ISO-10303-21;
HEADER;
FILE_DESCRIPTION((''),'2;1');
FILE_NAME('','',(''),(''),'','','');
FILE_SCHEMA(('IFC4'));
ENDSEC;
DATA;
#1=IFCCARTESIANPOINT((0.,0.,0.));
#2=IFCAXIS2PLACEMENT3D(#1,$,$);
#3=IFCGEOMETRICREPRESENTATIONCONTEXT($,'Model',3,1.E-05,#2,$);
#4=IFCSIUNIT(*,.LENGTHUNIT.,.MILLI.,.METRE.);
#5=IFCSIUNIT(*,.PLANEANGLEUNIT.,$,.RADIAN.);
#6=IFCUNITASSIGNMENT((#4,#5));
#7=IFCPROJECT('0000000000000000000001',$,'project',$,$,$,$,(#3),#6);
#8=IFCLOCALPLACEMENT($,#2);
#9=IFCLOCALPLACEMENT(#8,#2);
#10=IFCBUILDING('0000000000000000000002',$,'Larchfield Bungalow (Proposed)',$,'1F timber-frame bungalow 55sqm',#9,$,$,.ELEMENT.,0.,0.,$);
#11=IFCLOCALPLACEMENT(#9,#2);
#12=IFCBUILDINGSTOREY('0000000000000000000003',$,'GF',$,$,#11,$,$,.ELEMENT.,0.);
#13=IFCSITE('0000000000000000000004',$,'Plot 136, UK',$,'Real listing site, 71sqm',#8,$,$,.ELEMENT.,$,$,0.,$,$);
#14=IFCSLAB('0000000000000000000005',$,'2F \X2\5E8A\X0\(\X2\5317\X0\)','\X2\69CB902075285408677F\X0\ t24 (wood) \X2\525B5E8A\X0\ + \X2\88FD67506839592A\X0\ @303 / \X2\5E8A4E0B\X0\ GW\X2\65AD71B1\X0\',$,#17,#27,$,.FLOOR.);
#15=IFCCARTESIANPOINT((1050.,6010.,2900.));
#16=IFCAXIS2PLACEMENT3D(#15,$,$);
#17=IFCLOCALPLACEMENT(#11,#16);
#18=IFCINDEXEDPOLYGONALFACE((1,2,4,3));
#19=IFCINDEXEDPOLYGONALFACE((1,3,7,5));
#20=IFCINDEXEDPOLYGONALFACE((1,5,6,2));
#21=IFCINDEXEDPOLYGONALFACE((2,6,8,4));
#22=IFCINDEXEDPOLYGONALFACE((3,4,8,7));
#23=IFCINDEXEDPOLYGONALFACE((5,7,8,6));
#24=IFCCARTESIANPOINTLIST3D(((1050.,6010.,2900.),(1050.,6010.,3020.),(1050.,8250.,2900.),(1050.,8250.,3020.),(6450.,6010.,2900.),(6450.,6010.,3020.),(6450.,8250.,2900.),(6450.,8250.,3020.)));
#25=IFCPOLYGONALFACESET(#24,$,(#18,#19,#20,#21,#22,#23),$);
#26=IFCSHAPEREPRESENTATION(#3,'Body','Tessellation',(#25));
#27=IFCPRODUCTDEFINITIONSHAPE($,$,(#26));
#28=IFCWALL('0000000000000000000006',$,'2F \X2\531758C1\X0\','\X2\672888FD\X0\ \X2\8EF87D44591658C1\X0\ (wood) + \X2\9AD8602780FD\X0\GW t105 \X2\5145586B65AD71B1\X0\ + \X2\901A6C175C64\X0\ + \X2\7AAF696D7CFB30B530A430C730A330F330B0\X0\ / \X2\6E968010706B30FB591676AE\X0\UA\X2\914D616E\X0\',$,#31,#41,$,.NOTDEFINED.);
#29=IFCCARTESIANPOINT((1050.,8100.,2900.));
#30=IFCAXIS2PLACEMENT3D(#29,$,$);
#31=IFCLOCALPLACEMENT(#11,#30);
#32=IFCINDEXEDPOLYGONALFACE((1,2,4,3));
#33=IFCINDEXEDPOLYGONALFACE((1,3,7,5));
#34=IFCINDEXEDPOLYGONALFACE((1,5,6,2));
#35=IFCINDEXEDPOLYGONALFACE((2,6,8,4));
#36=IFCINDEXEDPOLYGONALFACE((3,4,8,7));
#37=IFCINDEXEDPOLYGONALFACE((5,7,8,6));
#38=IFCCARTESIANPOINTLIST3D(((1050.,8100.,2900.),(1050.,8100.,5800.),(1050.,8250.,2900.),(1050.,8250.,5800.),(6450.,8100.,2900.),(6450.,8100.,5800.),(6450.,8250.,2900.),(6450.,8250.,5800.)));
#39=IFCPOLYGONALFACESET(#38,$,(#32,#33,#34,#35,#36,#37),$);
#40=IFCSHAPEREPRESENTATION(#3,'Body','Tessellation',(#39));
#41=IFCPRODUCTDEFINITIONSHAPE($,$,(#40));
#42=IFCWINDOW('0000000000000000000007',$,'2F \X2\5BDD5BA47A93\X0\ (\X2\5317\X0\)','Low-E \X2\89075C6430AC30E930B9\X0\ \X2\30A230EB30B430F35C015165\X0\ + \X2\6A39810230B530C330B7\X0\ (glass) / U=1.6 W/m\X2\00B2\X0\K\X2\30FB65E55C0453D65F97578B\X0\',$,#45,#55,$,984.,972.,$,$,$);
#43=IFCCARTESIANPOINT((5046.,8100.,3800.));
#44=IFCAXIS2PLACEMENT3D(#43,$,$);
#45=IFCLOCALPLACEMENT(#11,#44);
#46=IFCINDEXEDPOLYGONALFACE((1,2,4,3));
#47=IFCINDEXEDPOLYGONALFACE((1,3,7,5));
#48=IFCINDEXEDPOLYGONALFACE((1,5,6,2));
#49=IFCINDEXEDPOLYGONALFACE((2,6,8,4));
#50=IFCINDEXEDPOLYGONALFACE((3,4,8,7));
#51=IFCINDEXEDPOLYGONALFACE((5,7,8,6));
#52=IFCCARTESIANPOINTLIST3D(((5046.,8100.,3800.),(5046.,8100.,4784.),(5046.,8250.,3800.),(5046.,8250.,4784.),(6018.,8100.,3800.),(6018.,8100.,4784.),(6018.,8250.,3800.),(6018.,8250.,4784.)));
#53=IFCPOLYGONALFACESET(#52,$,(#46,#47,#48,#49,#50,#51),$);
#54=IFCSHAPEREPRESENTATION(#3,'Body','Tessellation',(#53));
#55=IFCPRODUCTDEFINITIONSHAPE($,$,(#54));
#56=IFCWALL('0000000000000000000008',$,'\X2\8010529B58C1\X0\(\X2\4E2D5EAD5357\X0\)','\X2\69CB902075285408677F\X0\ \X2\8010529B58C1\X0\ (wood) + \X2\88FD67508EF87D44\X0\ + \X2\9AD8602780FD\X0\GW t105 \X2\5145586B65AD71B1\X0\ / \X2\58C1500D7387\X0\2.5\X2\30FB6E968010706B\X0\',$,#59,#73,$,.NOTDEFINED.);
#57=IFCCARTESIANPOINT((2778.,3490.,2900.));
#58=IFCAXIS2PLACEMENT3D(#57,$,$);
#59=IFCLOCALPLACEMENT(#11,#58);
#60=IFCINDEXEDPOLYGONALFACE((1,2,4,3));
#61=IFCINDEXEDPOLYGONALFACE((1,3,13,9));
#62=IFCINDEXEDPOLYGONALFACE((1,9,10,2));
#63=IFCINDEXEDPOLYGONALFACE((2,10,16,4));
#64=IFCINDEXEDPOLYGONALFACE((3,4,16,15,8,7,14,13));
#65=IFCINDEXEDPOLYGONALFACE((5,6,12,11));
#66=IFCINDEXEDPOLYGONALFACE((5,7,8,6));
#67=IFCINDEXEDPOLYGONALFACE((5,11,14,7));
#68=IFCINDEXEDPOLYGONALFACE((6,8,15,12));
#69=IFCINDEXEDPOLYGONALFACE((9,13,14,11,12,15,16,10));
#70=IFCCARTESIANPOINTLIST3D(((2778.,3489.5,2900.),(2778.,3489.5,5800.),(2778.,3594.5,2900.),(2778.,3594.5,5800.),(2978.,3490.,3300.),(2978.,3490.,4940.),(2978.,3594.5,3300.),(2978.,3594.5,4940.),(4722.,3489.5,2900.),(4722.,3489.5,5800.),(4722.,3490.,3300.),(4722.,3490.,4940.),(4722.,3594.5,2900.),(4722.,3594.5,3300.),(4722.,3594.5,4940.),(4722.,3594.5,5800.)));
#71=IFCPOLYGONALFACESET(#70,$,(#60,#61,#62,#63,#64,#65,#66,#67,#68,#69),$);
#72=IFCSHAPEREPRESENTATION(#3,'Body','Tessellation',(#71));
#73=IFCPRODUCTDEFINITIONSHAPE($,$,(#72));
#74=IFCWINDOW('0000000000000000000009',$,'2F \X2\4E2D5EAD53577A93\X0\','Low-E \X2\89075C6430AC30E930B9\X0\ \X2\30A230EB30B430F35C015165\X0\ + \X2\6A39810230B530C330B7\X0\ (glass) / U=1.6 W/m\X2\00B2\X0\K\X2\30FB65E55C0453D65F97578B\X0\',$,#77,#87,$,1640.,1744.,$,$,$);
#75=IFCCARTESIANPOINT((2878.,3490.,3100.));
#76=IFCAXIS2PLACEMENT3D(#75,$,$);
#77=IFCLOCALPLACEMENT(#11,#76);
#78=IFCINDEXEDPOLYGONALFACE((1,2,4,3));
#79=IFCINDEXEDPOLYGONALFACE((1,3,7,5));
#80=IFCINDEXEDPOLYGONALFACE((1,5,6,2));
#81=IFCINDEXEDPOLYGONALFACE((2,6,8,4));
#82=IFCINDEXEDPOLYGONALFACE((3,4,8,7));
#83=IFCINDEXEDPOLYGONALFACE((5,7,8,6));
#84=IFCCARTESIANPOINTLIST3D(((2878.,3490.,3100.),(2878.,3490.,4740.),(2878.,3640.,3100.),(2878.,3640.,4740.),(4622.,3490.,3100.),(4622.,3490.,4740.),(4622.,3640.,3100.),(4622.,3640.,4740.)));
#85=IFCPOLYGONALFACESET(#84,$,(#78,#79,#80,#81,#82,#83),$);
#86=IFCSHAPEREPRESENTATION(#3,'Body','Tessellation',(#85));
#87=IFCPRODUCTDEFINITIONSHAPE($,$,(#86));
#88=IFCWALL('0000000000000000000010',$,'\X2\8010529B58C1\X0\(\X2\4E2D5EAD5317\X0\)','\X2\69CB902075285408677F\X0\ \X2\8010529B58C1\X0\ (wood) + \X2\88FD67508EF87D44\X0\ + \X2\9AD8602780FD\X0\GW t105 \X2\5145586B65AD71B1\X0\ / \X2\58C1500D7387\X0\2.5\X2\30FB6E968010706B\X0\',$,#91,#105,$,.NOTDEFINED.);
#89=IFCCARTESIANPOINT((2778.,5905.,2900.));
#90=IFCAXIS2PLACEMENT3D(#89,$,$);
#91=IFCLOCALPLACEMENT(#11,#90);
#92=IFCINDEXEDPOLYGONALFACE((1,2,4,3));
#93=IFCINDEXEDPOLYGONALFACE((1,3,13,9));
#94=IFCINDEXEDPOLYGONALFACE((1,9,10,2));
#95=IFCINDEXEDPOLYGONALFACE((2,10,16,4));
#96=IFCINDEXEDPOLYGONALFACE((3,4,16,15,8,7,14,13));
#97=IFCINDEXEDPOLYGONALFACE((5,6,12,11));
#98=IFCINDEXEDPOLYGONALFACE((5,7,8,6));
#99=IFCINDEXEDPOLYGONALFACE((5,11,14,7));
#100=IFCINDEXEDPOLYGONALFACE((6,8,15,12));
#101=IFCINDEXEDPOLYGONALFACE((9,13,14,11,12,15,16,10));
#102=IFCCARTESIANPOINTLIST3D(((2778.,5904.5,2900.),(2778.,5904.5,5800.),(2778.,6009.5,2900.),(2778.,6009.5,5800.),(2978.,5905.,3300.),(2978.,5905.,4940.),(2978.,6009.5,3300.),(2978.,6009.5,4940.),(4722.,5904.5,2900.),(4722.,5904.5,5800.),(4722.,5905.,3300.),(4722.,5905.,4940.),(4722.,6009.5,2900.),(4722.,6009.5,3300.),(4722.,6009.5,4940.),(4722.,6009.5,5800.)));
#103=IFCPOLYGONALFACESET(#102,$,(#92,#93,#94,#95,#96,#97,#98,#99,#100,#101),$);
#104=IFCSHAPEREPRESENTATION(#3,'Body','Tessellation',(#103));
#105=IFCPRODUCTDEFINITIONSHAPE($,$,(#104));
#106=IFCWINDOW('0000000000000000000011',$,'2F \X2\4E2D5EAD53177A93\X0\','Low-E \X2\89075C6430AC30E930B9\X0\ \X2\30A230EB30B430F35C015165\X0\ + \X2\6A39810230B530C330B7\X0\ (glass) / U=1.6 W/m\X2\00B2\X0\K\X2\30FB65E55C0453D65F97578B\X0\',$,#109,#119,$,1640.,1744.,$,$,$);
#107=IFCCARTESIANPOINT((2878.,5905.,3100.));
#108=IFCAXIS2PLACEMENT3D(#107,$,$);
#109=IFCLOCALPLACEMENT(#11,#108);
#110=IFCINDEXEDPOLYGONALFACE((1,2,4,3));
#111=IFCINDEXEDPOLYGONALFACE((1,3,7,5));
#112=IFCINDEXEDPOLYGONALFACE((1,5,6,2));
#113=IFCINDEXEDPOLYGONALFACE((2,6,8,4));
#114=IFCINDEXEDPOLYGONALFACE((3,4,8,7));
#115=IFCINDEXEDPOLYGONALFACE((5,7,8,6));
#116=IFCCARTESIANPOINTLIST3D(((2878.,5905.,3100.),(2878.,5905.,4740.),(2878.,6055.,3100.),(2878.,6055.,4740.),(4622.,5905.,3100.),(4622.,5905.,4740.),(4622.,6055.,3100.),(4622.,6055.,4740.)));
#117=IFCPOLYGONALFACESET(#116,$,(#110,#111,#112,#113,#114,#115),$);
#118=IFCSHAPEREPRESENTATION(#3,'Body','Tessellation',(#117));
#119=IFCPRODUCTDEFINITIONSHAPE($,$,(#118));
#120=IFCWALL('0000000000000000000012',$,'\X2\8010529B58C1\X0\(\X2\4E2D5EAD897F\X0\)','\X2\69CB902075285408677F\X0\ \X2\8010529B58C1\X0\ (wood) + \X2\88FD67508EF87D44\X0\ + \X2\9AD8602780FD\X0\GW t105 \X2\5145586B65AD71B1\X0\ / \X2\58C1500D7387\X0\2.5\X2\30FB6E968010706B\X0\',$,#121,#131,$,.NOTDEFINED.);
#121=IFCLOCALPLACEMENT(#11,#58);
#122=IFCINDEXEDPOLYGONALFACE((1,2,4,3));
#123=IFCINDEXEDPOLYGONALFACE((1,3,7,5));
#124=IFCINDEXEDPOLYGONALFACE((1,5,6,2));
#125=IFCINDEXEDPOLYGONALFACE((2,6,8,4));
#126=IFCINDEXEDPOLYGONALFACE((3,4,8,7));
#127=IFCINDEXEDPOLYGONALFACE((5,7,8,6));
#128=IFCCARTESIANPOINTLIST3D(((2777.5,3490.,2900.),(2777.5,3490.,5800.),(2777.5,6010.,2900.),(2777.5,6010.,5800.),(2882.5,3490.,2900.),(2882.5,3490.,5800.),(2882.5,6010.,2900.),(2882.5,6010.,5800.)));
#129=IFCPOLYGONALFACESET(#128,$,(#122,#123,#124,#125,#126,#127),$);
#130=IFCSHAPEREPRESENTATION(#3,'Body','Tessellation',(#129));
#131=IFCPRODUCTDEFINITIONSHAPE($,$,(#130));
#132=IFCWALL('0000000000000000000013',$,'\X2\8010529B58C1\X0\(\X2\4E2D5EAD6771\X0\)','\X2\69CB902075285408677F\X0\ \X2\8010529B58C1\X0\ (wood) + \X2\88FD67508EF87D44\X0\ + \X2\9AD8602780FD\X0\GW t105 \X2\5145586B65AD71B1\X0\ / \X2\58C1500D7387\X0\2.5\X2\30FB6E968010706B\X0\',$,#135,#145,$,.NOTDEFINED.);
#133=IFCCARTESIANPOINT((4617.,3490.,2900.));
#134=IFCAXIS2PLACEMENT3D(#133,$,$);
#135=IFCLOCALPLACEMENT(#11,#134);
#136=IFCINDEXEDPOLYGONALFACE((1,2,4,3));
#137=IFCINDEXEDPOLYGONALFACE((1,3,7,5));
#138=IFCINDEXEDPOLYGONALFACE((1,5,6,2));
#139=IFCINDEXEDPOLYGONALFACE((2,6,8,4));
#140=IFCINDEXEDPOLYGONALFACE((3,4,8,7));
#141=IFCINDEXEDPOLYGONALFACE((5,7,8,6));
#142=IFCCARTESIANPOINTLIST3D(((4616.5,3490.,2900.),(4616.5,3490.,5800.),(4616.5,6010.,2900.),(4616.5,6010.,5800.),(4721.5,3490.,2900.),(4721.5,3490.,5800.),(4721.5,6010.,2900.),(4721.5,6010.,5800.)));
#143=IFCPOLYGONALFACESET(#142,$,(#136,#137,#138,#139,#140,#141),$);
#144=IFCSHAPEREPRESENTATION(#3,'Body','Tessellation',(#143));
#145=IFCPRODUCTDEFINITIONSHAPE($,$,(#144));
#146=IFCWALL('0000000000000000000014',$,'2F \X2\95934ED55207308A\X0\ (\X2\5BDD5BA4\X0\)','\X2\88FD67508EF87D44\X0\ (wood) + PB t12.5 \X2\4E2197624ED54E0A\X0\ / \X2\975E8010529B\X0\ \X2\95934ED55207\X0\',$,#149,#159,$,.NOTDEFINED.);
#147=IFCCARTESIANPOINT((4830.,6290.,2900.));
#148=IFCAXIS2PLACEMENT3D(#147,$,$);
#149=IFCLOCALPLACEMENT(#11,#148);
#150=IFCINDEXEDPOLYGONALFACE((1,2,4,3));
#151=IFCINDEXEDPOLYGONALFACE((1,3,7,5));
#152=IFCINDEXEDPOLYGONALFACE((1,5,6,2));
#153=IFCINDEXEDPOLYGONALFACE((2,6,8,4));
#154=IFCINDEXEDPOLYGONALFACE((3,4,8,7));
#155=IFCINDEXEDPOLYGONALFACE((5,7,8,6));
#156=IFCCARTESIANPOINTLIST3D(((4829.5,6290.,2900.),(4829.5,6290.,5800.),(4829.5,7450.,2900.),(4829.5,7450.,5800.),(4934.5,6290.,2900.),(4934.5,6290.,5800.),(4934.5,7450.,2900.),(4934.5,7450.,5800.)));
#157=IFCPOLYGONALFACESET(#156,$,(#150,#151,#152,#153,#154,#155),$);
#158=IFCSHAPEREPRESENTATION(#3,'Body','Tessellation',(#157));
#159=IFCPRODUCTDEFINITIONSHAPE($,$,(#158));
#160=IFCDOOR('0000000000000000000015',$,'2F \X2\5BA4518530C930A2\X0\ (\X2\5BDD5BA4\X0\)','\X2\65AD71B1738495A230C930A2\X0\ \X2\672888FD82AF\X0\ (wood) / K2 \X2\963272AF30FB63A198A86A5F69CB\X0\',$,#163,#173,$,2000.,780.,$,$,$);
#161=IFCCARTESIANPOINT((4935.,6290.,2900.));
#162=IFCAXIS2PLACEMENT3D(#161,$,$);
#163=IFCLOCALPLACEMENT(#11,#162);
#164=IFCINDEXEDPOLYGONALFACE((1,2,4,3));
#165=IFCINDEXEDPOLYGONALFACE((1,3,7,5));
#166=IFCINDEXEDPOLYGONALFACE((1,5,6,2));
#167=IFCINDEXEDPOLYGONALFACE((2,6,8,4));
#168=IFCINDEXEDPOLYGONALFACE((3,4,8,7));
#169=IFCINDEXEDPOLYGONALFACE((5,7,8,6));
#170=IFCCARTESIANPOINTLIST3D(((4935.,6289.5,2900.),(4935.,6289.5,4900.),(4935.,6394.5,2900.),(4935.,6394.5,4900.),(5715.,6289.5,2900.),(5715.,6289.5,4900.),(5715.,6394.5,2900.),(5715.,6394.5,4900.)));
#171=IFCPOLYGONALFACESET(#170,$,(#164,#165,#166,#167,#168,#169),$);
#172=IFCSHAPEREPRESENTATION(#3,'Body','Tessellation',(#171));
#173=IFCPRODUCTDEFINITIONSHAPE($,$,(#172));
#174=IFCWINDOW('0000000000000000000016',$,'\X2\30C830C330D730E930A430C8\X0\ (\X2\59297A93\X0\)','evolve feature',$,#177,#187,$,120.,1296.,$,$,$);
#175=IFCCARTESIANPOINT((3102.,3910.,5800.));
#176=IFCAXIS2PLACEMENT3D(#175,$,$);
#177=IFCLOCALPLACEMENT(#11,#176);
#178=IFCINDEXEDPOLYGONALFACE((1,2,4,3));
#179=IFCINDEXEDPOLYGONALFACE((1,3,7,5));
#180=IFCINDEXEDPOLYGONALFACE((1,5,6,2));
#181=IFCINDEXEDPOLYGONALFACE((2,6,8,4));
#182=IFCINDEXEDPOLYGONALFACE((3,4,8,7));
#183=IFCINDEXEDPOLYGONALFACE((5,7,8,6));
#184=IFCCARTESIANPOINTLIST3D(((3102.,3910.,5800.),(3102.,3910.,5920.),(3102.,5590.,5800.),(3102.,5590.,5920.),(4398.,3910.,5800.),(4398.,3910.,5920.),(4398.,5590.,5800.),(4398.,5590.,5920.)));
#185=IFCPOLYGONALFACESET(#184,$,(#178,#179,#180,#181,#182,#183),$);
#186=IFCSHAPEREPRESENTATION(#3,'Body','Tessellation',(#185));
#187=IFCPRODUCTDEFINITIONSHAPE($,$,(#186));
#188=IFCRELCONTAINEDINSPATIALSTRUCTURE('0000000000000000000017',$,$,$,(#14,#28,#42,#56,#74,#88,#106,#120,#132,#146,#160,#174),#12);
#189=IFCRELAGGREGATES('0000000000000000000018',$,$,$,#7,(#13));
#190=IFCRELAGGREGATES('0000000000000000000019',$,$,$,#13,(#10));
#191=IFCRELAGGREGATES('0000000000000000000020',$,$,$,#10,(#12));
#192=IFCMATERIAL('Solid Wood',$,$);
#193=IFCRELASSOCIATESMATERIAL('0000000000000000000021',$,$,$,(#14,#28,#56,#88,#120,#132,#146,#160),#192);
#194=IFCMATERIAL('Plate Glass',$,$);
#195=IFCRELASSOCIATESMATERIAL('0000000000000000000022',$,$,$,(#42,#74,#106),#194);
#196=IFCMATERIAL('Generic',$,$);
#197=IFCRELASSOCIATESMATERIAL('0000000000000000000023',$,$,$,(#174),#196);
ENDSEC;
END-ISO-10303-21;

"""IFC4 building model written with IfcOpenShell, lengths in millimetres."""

from ifc_helpers import new_model, si_unit, frame, frame_2d, origin, place, context, project, spatial, rectangle, extrude, material, element, fill, save


model = new_model("IFC4")

# Units and contexts
model_context = context("Model", 3, precision=1e-05, world=origin())
ifc_project = project(units=[si_unit("LENGTHUNIT", "METRE", prefix="MILLI"), si_unit("PLANEANGLEUNIT", "RADIAN")], contexts=[model_context])

# Site, building, storey
site_placement = place(None, origin())
site = spatial("IfcSite", under=ifc_project, at=site_placement, Name="Plot 136, UK", ObjectType="Real listing site, 71sqm", CompositionType="ELEMENT", RefElevation=0.0)
building_placement = place(site_placement, origin())
building = spatial("IfcBuilding", under=site, at=building_placement, Name="Larchfield Bungalow (Proposed)", ObjectType="1F timber-frame bungalow 55sqm", CompositionType="ELEMENT", ElevationOfRefHeight=0.0, ElevationOfTerrain=0.0)
storey_placement = place(building_placement, origin())
storey = spatial("IfcBuildingStorey", under=building, at=storey_placement, Name="GF", CompositionType="ELEMENT", Elevation=0.0)

# Slab
ifc_material_1 = material(Name="Solid Wood")
slab_placement = place(storey_placement, frame((1050.0, 6010.0, 2900.0)))
element("IfcSlab", 1, at=slab_placement, inside=storey, material=ifc_material_1, Name="2F 床(北)", Description="構造用合板 t24 (wood) 剛床 + 製材根太 @303 / 床下 GW断熱", PredefinedType="FLOOR", context=model_context, shape_type="SweptSolid", body=[
    extrude(rectangle(XDim=5400.0, YDim=2240.0, at=frame_2d((2700.0, 1120.0))), frame((1050.0, 6010.0, 2900.0)), (0.0, 0.0, 1.0), 120.0),
])

# Walls, openings, windows
wall_1_placement = place(storey_placement, frame((1050.0, 8100.0, 2900.0)))
wall_1 = element("IfcWall", 2, at=wall_1_placement, inside=storey, material=ifc_material_1, Name="2F 北壁", Description="木製 軸組外壁 (wood) + 高性能GW t105 充填断熱 + 通気層 + 窯業系サイディング / 準耐火・外皮UA配慮", PredefinedType="NOTDEFINED", context=model_context, shape_type="SweptSolid", body=[
    extrude(rectangle(XDim=5400.0, YDim=150.0, at=frame_2d((2700.0, 75.0))), frame((1050.0, 8100.0, 2900.0)), (0.0, 0.0, 1.0), 2900.0),
])
opening_1_placement = place(storey_placement, frame((5046.0, 8100.0, 3800.0)))
opening_1 = element("IfcOpeningElement", 3, at=opening_1_placement, cuts=wall_1, PredefinedType="NOTDEFINED", context=model_context, shape_type="SweptSolid", body=[
    extrude(rectangle(XDim=972.0, YDim=150.0, at=frame_2d((486.0, 75.0))), frame((5046.0, 8100.0, 3800.0)), (0.0, 0.0, 1.0), 984.0),
])
ifc_material_2 = material(Name="Plate Glass")
window_1_placement = place(storey_placement, frame((5046.0, 8100.0, 3800.0)))
window_1 = element("IfcWindow", 4, at=window_1_placement, inside=storey, material=ifc_material_2, Name="2F 寝室窓 (北)", Description="Low-E 複層ガラス アルゴン封入 + 樹脂サッシ (glass) / U=1.6 W/m²K・日射取得型", OverallHeight=984.0, OverallWidth=972.0, context=model_context, shape_type="SweptSolid", body=[
    extrude(rectangle(XDim=972.0, YDim=150.0, at=frame_2d((486.0, 75.0))), frame((5046.0, 8100.0, 3800.0)), (0.0, 0.0, 1.0), 984.0),
])
fill(opening_1, window_1)
wall_2_placement = place(storey_placement, frame((2778.0, 3490.0, 2900.0)))
wall_2 = element("IfcWall", 5, at=wall_2_placement, inside=storey, material=ifc_material_1, Name="耐力壁(中庭南)", Description="構造用合板 耐力壁 (wood) + 製材軸組 + 高性能GW t105 充填断熱 / 壁倍率2.5・準耐火", PredefinedType="NOTDEFINED", context=model_context, shape_type="SweptSolid", body=[
    extrude(rectangle(XDim=1944.0, YDim=105.0, at=frame_2d((972.0, 52.0))), frame((2778.0, 3490.0, 2900.0)), (0.0, 0.0, 1.0), 2900.0),
])
opening_2_placement = place(storey_placement, frame((2878.0, 3490.0, 3100.0)))
opening_2 = element("IfcOpeningElement", 6, at=opening_2_placement, cuts=wall_2, PredefinedType="NOTDEFINED", context=model_context, shape_type="SweptSolid", body=[
    extrude(rectangle(XDim=1744.0, YDim=150.0, at=frame_2d((872.0, 75.0))), frame((2878.0, 3490.0, 3100.0)), (0.0, 0.0, 1.0), 1640.0),
])
window_2_placement = place(storey_placement, frame((2878.0, 3490.0, 3100.0)))
window_2 = element("IfcWindow", 7, at=window_2_placement, inside=storey, material=ifc_material_2, Name="2F 中庭南窓", Description="Low-E 複層ガラス アルゴン封入 + 樹脂サッシ (glass) / U=1.6 W/m²K・日射取得型", OverallHeight=1640.0, OverallWidth=1744.0, context=model_context, shape_type="SweptSolid", body=[
    extrude(rectangle(XDim=1744.0, YDim=150.0, at=frame_2d((872.0, 75.0))), frame((2878.0, 3490.0, 3100.0)), (0.0, 0.0, 1.0), 1640.0),
])
fill(opening_2, window_2)
wall_3_placement = place(storey_placement, frame((2778.0, 5905.0, 2900.0)))
wall_3 = element("IfcWall", 8, at=wall_3_placement, inside=storey, material=ifc_material_1, Name="耐力壁(中庭北)", Description="構造用合板 耐力壁 (wood) + 製材軸組 + 高性能GW t105 充填断熱 / 壁倍率2.5・準耐火", PredefinedType="NOTDEFINED", context=model_context, shape_type="SweptSolid", body=[
    extrude(rectangle(XDim=1944.0, YDim=105.0, at=frame_2d((972.0, 52.0))), frame((2778.0, 5905.0, 2900.0)), (0.0, 0.0, 1.0), 2900.0),
])
opening_3_placement = place(storey_placement, frame((2878.0, 5905.0, 3100.0)))
opening_3 = element("IfcOpeningElement", 9, at=opening_3_placement, cuts=wall_3, PredefinedType="NOTDEFINED", context=model_context, shape_type="SweptSolid", body=[
    extrude(rectangle(XDim=1744.0, YDim=150.0, at=frame_2d((872.0, 75.0))), frame((2878.0, 5905.0, 3100.0)), (0.0, 0.0, 1.0), 1640.0),
])
window_3_placement = place(storey_placement, frame((2878.0, 5905.0, 3100.0)))
window_3 = element("IfcWindow", 10, at=window_3_placement, inside=storey, material=ifc_material_2, Name="2F 中庭北窓", Description="Low-E 複層ガラス アルゴン封入 + 樹脂サッシ (glass) / U=1.6 W/m²K・日射取得型", OverallHeight=1640.0, OverallWidth=1744.0, context=model_context, shape_type="SweptSolid", body=[
    extrude(rectangle(XDim=1744.0, YDim=150.0, at=frame_2d((872.0, 75.0))), frame((2878.0, 5905.0, 3100.0)), (0.0, 0.0, 1.0), 1640.0),
])
fill(opening_3, window_3)

# Walls
wall_4_placement = place(storey_placement, frame((2778.0, 3490.0, 2900.0)))
element("IfcWall", 11, at=wall_4_placement, inside=storey, material=ifc_material_1, Name="耐力壁(中庭西)", Description="構造用合板 耐力壁 (wood) + 製材軸組 + 高性能GW t105 充填断熱 / 壁倍率2.5・準耐火", PredefinedType="NOTDEFINED", context=model_context, shape_type="SweptSolid", body=[
    extrude(rectangle(XDim=105.0, YDim=2520.0, at=frame_2d((52.0, 1260.0))), frame((2778.0, 3490.0, 2900.0)), (0.0, 0.0, 1.0), 2900.0),
])
wall_5_placement = place(storey_placement, frame((4617.0, 3490.0, 2900.0)))
element("IfcWall", 12, at=wall_5_placement, inside=storey, material=ifc_material_1, Name="耐力壁(中庭東)", Description="構造用合板 耐力壁 (wood) + 製材軸組 + 高性能GW t105 充填断熱 / 壁倍率2.5・準耐火", PredefinedType="NOTDEFINED", context=model_context, shape_type="SweptSolid", body=[
    extrude(rectangle(XDim=105.0, YDim=2520.0, at=frame_2d((52.0, 1260.0))), frame((4617.0, 3490.0, 2900.0)), (0.0, 0.0, 1.0), 2900.0),
])
wall_6_placement = place(storey_placement, frame((4830.0, 6290.0, 2900.0)))
element("IfcWall", 13, at=wall_6_placement, inside=storey, material=ifc_material_1, Name="2F 間仕切り (寝室)", Description="製材軸組 (wood) + PB t12.5 両面仕上 / 非耐力 間仕切", PredefinedType="NOTDEFINED", context=model_context, shape_type="SweptSolid", body=[
    extrude(rectangle(XDim=105.0, YDim=1160.0, at=frame_2d((52.0, 580.0))), frame((4830.0, 6290.0, 2900.0)), (0.0, 0.0, 1.0), 2900.0),
])

# Door
door_placement = place(storey_placement, frame((4935.0, 6290.0, 2900.0)))
element("IfcDoor", 14, at=door_placement, inside=storey, material=ifc_material_1, Name="2F 室内ドア (寝室)", Description="断熱玄関ドア 木製芯 (wood) / K2 防犯・採風機構", OverallHeight=2000.0, OverallWidth=780.0, context=model_context, shape_type="SweptSolid", body=[
    extrude(rectangle(XDim=780.0, YDim=105.0, at=frame_2d((390.0, 52.0))), frame((4935.0, 6290.0, 2900.0)), (0.0, 0.0, 1.0), 2000.0),
])

# Window
ifc_material_3 = material(Name="Generic")
window_4_placement = place(storey_placement, frame((3102.0, 3910.0, 5800.0)))
element("IfcWindow", 15, at=window_4_placement, inside=storey, material=ifc_material_3, Name="トップライト (天窓)", Description="evolve feature", OverallHeight=120.0, OverallWidth=1296.0, context=model_context, shape_type="SweptSolid", body=[
    extrude(rectangle(XDim=1296.0, YDim=1680.0, at=frame_2d((648.0, 840.0))), frame((3102.0, 3910.0, 5800.0)), (0.0, 0.0, 1.0), 120.0),
])

save(model, "model.ifc")
